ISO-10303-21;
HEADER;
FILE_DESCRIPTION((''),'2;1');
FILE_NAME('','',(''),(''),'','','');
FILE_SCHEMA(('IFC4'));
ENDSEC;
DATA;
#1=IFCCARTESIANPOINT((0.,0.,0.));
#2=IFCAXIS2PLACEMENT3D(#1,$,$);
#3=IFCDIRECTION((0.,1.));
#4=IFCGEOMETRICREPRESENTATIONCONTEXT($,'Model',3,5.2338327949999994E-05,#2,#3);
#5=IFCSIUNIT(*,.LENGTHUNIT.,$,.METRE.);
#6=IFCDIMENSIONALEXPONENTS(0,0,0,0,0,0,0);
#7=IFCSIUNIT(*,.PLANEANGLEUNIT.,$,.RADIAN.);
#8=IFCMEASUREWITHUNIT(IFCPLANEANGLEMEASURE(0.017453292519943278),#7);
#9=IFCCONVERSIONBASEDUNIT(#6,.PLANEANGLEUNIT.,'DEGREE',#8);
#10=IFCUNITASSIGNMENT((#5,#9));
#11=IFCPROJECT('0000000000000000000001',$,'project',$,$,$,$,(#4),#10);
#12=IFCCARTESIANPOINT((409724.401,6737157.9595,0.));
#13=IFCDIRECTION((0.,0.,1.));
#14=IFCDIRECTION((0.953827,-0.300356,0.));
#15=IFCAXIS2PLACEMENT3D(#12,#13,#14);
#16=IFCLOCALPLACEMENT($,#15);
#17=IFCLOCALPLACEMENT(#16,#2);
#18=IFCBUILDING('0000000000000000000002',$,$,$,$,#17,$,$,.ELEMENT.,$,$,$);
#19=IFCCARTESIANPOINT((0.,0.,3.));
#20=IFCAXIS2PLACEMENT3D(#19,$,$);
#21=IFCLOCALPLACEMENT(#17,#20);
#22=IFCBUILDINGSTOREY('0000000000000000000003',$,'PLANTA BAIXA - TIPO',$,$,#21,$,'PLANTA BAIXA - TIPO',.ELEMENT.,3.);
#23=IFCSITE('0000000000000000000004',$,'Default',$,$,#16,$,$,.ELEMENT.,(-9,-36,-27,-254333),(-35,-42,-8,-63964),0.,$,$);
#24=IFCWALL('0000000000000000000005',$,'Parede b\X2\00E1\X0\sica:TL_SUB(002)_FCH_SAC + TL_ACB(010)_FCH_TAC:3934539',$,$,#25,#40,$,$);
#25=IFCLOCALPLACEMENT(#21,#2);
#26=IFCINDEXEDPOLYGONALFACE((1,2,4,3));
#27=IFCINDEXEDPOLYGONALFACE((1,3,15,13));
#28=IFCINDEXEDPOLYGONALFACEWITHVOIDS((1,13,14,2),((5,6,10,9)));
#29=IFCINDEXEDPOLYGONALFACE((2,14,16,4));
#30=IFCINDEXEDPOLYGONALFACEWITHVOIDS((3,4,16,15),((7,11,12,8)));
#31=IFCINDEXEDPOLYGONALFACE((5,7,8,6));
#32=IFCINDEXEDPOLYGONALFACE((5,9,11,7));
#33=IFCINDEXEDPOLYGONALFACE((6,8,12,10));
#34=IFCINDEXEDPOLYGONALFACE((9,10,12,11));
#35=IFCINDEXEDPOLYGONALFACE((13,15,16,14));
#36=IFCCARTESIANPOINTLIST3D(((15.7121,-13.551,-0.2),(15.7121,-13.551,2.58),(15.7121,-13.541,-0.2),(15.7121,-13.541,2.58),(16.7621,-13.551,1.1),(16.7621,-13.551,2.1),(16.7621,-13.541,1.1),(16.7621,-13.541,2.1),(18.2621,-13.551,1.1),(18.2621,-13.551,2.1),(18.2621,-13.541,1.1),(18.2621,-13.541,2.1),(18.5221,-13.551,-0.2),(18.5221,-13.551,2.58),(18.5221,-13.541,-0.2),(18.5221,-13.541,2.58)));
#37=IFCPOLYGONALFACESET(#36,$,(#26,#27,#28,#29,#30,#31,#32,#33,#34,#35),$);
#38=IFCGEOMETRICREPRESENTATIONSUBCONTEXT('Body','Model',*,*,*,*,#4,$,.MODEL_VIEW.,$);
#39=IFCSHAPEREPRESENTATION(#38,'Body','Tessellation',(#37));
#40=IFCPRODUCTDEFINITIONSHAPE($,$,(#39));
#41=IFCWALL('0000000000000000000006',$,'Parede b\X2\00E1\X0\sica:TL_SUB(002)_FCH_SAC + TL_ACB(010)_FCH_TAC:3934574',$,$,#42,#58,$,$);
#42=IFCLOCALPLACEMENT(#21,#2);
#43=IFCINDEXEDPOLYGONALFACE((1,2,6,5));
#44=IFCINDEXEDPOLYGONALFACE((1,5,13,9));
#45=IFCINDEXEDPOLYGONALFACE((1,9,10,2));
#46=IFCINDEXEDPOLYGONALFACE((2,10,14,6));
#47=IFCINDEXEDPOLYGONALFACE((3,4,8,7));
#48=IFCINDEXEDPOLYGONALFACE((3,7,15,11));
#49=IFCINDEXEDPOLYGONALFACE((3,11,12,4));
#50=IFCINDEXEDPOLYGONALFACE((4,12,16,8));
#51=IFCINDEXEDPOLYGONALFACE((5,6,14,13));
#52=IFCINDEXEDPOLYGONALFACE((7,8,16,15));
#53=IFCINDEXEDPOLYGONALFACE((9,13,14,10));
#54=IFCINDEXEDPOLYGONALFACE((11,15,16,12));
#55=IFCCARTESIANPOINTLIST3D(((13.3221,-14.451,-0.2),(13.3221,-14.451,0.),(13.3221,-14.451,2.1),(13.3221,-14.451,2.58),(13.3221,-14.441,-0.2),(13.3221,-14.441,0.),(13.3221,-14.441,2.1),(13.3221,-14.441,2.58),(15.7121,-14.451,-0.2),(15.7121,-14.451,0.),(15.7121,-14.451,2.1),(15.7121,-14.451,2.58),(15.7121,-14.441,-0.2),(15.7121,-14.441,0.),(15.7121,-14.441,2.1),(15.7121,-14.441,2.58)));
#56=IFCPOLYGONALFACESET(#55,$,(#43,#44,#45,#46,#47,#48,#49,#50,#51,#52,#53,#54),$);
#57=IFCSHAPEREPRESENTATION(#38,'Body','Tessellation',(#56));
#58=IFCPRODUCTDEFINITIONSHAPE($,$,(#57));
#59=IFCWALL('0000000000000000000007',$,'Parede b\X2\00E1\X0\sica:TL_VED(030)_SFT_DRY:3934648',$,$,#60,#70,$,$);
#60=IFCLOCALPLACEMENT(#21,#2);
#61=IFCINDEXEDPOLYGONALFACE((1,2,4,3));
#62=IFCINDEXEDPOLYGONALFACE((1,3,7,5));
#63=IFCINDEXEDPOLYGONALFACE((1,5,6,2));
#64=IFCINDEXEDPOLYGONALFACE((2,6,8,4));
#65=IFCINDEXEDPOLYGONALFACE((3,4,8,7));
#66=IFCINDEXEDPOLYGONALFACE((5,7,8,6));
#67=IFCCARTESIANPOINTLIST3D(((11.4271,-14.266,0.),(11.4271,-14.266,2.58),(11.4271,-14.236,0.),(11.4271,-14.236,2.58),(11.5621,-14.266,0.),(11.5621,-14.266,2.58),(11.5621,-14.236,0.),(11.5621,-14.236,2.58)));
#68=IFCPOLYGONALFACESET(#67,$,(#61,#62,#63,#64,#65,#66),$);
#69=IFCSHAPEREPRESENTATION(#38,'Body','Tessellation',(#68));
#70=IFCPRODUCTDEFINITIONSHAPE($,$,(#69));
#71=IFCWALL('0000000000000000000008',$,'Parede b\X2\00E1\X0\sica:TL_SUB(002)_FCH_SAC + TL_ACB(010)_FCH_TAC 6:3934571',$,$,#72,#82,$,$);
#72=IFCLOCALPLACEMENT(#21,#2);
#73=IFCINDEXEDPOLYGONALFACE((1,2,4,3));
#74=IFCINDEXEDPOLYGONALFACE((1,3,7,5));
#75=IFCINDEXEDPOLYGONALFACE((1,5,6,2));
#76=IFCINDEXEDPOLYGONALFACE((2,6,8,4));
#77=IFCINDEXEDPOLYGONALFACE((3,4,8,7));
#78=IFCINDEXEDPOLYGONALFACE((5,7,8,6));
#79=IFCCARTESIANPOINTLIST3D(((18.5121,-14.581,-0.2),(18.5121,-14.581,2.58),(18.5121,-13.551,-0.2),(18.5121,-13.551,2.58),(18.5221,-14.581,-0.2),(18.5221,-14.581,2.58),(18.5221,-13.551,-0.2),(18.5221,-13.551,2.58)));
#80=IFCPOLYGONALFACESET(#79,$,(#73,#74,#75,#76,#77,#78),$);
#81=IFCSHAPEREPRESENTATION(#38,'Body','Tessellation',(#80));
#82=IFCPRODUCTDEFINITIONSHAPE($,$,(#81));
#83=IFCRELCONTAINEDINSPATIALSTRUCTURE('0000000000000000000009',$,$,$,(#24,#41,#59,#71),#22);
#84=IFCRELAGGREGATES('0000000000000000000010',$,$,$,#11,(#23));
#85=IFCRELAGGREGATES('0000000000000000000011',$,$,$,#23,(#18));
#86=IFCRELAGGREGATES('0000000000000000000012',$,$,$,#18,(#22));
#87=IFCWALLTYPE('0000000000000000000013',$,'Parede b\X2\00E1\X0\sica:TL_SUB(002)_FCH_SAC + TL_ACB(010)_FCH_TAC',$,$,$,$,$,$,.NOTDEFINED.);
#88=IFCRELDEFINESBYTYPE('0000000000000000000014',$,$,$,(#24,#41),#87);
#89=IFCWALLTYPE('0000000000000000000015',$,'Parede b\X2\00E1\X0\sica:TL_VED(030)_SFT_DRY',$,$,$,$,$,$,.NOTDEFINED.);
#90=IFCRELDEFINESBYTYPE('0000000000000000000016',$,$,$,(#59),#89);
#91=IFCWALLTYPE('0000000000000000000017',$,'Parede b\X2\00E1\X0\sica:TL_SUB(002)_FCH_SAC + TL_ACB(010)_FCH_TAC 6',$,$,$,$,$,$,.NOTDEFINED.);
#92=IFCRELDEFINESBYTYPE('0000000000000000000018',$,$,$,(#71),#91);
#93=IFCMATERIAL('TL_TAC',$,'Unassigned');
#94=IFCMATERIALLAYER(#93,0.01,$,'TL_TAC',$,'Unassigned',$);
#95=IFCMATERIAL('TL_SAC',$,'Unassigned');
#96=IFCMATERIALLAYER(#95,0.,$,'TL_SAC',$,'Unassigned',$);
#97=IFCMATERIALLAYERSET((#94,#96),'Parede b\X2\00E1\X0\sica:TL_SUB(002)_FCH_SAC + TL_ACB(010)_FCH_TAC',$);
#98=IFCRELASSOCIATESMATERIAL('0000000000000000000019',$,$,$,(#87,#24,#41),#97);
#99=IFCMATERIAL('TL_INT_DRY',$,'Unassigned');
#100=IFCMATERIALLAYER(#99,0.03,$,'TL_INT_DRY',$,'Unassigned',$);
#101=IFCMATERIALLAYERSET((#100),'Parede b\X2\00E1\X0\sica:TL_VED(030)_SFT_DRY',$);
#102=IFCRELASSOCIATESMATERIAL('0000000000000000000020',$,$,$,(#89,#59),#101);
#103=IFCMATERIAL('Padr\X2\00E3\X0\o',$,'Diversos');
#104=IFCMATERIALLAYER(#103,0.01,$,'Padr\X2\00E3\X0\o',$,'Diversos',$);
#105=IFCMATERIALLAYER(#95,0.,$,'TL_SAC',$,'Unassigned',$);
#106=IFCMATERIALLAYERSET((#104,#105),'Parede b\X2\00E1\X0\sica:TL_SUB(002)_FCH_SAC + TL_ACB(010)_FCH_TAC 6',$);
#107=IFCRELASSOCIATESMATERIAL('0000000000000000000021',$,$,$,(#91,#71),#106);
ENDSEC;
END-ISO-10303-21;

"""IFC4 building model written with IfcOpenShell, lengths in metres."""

from ifc_helpers import new_model, entity, si_unit, converted_unit, direction, frame, frame_2d, origin, place, context, subcontext, project, spatial, rectangle, extrude, material, layer, layer_set, layer_usage, type_object, element, save


model = new_model("IFC4")

# Units and contexts
model_context = context("Model", 3, precision=5.2338327949999994e-05, world=origin(), true_north=direction((0.0, 1.0)))
body_context = subcontext(model_context, "Body", "Model", "MODEL_VIEW")
ifc_project = project(units=[si_unit("LENGTHUNIT", "METRE"), converted_unit("PLANEANGLEUNIT", "DEGREE", entity("IfcPlaneAngleMeasure", 0.017453292519943278), si_unit("PLANEANGLEUNIT", "RADIAN"), dimensions=[0, 0, 0, 0, 0, 0, 0])], contexts=[model_context])

# Site, building, storey
site_placement = place(None, frame((409724.401, 6737157.9595, 0.0), z_axis=(0.0, 0.0, 1.0), x_axis=(0.953827, -0.300356, 0.0)))
site = spatial("IfcSite", under=ifc_project, at=site_placement, Name="Default", CompositionType="ELEMENT", RefLatitude=(-9, -36, -27, -254333), RefLongitude=(-35, -42, -8, -63964), RefElevation=0.0)
building_placement = place(site_placement, origin())
building = spatial("IfcBuilding", under=site, at=building_placement, CompositionType="ELEMENT")
storey_placement = place(building_placement, frame((0.0, 0.0, 3.0)))
storey = spatial("IfcBuildingStorey", under=building, at=storey_placement, Name="PLANTA BAIXA - TIPO", LongName="PLANTA BAIXA - TIPO", CompositionType="ELEMENT", Elevation=3.0)

# Shared definitions
ifc_material_1 = material(Name="TL_SAC", Category="Unassigned")

# Walls, openings
ifc_material_2 = material(Name="TL_TAC", Category="Unassigned")
ifc_layer_1 = layer(ifc_material_2, 0.01, Name="TL_TAC", Category="Unassigned")
ifc_layer_2 = layer(ifc_material_1, 0.0, Name="TL_SAC", Category="Unassigned")
ifc_layer_set_1 = layer_set([ifc_layer_1, ifc_layer_2], Name="Parede básica:TL_SUB(002)_FCH_SAC + TL_ACB(010)_FCH_TAC")
ifc_layer_usage_1 = layer_usage(ifc_layer_set_1, "AXIS2", "NEGATIVE", 0.005)
wall_type_1 = type_object("IfcWallType", Name="Parede básica:TL_SUB(002)_FCH_SAC + TL_ACB(010)_FCH_TAC", PredefinedType="NOTDEFINED", material=ifc_layer_set_1)
wall_1_placement = place(storey_placement, frame((15.7121, -13.546, -0.2)))
wall_1 = element("IfcWall", 1, at=wall_1_placement, inside=storey, type_object=wall_type_1, material=ifc_layer_usage_1, Name="Parede básica:TL_SUB(002)_FCH_SAC + TL_ACB(010)_FCH_TAC:3934539", context=body_context, shape_type="SweptSolid", body=[
    extrude(rectangle(XDim=2.81, YDim=0.01, at=frame_2d((1.405, 0.0), x_axis=(-1.0, 0.0))), origin(), (0.0, 0.0, 1.0), 2.78),
])
opening_1_placement = place(wall_1_placement, frame((-15.7121, 13.546, 1.3)))
element("IfcOpeningElement", 2, at=opening_1_placement, cuts=wall_1, PredefinedType="OPENING", context=body_context, shape_type="SweptSolid", body=[
    extrude(rectangle(XDim=1.0, YDim=1.5, at=frame_2d((0.0, 0.0), x_axis=(0.0, 1.0))), frame((17.5121, -15.175, 0.5), z_axis=(0.0, 1.0, 0.0), x_axis=(1.0, 0.0, 0.0)), (0.0, 0.0, 1.0), 3.048),
])
ifc_layer_usage_2 = layer_usage(ifc_layer_set_1, "AXIS2", "NEGATIVE", 0.005)
wall_2_placement = place(storey_placement, frame((13.3221, -14.446, -0.2)))
wall_2 = element("IfcWall", 3, at=wall_2_placement, inside=storey, type_object=wall_type_1, material=ifc_layer_usage_2, Name="Parede básica:TL_SUB(002)_FCH_SAC + TL_ACB(010)_FCH_TAC:3934574", context=body_context, shape_type="SweptSolid", body=[
    extrude(rectangle(XDim=2.39, YDim=0.01, at=frame_2d((1.195, 0.0), x_axis=(-1.0, 0.0))), origin(), (0.0, 0.0, 1.0), 2.78),
])
opening_2_placement = place(wall_2_placement, frame((-13.3221, 14.446, 0.2)))
element("IfcOpeningElement", 4, at=opening_2_placement, cuts=wall_2, PredefinedType="OPENING", context=body_context, shape_type="SweptSolid", body=[
    extrude(rectangle(XDim=2.1, YDim=2.4, at=frame_2d((0.0, 0.0), x_axis=(0.0, 1.0))), frame((14.5121, -15.975, 1.05), z_axis=(0.0, 1.0, 0.0), x_axis=(-1.0, 0.0, 0.0)), (0.0, 0.0, 1.0), 3.048),
])

# Walls
ifc_material_3 = material(Name="TL_INT_DRY", Category="Unassigned")
ifc_layer_3 = layer(ifc_material_3, 0.03, Name="TL_INT_DRY", Category="Unassigned")
ifc_layer_set_2 = layer_set([ifc_layer_3], Name="Parede básica:TL_VED(030)_SFT_DRY")
ifc_layer_usage_3 = layer_usage(ifc_layer_set_2, "AXIS2", "NEGATIVE", 0.015)
wall_type_2 = type_object("IfcWallType", Name="Parede básica:TL_VED(030)_SFT_DRY", PredefinedType="NOTDEFINED", material=ifc_layer_set_2)
wall_3_placement = place(storey_placement, frame((11.5621, -14.251, 0.0), z_axis=(0.0, 0.0, 1.0), x_axis=(-1.0, 0.0, 0.0)))
element("IfcWall", 5, at=wall_3_placement, inside=storey, type_object=wall_type_2, material=ifc_layer_usage_3, Name="Parede básica:TL_VED(030)_SFT_DRY:3934648", context=body_context, shape_type="SweptSolid", body=[
    extrude(rectangle(XDim=0.135, YDim=0.03, at=frame_2d((0.0675, 0.0), x_axis=(-1.0, 0.0))), origin(), (0.0, 0.0, 1.0), 2.58),
])
ifc_material_4 = material(Name="Padrão", Category="Diversos")
ifc_layer_4 = layer(ifc_material_4, 0.01, Name="Padrão", Category="Diversos")
ifc_layer_5 = layer(ifc_material_1, 0.0, Name="TL_SAC", Category="Unassigned")
ifc_layer_set_3 = layer_set([ifc_layer_4, ifc_layer_5], Name="Parede básica:TL_SUB(002)_FCH_SAC + TL_ACB(010)_FCH_TAC 6")
ifc_layer_usage_4 = layer_usage(ifc_layer_set_3, "AXIS2", "POSITIVE", -0.005)
wall_type_3 = type_object("IfcWallType", Name="Parede básica:TL_SUB(002)_FCH_SAC + TL_ACB(010)_FCH_TAC 6", PredefinedType="NOTDEFINED", material=ifc_layer_set_3)
wall_4_placement = place(storey_placement, frame((18.5171, -13.551, -0.2), z_axis=(0.0, 0.0, 1.0), x_axis=(0.0, -1.0, 0.0)))
element("IfcWall", 6, at=wall_4_placement, inside=storey, type_object=wall_type_3, material=ifc_layer_usage_4, Name="Parede básica:TL_SUB(002)_FCH_SAC + TL_ACB(010)_FCH_TAC 6:3934571", context=body_context, shape_type="SweptSolid", body=[
    extrude(rectangle(XDim=1.03, YDim=0.01, at=frame_2d((0.515, 0.0), x_axis=(-1.0, 0.0))), origin(), (0.0, 0.0, 1.0), 2.78),
])

save(model, "model.ifc")
